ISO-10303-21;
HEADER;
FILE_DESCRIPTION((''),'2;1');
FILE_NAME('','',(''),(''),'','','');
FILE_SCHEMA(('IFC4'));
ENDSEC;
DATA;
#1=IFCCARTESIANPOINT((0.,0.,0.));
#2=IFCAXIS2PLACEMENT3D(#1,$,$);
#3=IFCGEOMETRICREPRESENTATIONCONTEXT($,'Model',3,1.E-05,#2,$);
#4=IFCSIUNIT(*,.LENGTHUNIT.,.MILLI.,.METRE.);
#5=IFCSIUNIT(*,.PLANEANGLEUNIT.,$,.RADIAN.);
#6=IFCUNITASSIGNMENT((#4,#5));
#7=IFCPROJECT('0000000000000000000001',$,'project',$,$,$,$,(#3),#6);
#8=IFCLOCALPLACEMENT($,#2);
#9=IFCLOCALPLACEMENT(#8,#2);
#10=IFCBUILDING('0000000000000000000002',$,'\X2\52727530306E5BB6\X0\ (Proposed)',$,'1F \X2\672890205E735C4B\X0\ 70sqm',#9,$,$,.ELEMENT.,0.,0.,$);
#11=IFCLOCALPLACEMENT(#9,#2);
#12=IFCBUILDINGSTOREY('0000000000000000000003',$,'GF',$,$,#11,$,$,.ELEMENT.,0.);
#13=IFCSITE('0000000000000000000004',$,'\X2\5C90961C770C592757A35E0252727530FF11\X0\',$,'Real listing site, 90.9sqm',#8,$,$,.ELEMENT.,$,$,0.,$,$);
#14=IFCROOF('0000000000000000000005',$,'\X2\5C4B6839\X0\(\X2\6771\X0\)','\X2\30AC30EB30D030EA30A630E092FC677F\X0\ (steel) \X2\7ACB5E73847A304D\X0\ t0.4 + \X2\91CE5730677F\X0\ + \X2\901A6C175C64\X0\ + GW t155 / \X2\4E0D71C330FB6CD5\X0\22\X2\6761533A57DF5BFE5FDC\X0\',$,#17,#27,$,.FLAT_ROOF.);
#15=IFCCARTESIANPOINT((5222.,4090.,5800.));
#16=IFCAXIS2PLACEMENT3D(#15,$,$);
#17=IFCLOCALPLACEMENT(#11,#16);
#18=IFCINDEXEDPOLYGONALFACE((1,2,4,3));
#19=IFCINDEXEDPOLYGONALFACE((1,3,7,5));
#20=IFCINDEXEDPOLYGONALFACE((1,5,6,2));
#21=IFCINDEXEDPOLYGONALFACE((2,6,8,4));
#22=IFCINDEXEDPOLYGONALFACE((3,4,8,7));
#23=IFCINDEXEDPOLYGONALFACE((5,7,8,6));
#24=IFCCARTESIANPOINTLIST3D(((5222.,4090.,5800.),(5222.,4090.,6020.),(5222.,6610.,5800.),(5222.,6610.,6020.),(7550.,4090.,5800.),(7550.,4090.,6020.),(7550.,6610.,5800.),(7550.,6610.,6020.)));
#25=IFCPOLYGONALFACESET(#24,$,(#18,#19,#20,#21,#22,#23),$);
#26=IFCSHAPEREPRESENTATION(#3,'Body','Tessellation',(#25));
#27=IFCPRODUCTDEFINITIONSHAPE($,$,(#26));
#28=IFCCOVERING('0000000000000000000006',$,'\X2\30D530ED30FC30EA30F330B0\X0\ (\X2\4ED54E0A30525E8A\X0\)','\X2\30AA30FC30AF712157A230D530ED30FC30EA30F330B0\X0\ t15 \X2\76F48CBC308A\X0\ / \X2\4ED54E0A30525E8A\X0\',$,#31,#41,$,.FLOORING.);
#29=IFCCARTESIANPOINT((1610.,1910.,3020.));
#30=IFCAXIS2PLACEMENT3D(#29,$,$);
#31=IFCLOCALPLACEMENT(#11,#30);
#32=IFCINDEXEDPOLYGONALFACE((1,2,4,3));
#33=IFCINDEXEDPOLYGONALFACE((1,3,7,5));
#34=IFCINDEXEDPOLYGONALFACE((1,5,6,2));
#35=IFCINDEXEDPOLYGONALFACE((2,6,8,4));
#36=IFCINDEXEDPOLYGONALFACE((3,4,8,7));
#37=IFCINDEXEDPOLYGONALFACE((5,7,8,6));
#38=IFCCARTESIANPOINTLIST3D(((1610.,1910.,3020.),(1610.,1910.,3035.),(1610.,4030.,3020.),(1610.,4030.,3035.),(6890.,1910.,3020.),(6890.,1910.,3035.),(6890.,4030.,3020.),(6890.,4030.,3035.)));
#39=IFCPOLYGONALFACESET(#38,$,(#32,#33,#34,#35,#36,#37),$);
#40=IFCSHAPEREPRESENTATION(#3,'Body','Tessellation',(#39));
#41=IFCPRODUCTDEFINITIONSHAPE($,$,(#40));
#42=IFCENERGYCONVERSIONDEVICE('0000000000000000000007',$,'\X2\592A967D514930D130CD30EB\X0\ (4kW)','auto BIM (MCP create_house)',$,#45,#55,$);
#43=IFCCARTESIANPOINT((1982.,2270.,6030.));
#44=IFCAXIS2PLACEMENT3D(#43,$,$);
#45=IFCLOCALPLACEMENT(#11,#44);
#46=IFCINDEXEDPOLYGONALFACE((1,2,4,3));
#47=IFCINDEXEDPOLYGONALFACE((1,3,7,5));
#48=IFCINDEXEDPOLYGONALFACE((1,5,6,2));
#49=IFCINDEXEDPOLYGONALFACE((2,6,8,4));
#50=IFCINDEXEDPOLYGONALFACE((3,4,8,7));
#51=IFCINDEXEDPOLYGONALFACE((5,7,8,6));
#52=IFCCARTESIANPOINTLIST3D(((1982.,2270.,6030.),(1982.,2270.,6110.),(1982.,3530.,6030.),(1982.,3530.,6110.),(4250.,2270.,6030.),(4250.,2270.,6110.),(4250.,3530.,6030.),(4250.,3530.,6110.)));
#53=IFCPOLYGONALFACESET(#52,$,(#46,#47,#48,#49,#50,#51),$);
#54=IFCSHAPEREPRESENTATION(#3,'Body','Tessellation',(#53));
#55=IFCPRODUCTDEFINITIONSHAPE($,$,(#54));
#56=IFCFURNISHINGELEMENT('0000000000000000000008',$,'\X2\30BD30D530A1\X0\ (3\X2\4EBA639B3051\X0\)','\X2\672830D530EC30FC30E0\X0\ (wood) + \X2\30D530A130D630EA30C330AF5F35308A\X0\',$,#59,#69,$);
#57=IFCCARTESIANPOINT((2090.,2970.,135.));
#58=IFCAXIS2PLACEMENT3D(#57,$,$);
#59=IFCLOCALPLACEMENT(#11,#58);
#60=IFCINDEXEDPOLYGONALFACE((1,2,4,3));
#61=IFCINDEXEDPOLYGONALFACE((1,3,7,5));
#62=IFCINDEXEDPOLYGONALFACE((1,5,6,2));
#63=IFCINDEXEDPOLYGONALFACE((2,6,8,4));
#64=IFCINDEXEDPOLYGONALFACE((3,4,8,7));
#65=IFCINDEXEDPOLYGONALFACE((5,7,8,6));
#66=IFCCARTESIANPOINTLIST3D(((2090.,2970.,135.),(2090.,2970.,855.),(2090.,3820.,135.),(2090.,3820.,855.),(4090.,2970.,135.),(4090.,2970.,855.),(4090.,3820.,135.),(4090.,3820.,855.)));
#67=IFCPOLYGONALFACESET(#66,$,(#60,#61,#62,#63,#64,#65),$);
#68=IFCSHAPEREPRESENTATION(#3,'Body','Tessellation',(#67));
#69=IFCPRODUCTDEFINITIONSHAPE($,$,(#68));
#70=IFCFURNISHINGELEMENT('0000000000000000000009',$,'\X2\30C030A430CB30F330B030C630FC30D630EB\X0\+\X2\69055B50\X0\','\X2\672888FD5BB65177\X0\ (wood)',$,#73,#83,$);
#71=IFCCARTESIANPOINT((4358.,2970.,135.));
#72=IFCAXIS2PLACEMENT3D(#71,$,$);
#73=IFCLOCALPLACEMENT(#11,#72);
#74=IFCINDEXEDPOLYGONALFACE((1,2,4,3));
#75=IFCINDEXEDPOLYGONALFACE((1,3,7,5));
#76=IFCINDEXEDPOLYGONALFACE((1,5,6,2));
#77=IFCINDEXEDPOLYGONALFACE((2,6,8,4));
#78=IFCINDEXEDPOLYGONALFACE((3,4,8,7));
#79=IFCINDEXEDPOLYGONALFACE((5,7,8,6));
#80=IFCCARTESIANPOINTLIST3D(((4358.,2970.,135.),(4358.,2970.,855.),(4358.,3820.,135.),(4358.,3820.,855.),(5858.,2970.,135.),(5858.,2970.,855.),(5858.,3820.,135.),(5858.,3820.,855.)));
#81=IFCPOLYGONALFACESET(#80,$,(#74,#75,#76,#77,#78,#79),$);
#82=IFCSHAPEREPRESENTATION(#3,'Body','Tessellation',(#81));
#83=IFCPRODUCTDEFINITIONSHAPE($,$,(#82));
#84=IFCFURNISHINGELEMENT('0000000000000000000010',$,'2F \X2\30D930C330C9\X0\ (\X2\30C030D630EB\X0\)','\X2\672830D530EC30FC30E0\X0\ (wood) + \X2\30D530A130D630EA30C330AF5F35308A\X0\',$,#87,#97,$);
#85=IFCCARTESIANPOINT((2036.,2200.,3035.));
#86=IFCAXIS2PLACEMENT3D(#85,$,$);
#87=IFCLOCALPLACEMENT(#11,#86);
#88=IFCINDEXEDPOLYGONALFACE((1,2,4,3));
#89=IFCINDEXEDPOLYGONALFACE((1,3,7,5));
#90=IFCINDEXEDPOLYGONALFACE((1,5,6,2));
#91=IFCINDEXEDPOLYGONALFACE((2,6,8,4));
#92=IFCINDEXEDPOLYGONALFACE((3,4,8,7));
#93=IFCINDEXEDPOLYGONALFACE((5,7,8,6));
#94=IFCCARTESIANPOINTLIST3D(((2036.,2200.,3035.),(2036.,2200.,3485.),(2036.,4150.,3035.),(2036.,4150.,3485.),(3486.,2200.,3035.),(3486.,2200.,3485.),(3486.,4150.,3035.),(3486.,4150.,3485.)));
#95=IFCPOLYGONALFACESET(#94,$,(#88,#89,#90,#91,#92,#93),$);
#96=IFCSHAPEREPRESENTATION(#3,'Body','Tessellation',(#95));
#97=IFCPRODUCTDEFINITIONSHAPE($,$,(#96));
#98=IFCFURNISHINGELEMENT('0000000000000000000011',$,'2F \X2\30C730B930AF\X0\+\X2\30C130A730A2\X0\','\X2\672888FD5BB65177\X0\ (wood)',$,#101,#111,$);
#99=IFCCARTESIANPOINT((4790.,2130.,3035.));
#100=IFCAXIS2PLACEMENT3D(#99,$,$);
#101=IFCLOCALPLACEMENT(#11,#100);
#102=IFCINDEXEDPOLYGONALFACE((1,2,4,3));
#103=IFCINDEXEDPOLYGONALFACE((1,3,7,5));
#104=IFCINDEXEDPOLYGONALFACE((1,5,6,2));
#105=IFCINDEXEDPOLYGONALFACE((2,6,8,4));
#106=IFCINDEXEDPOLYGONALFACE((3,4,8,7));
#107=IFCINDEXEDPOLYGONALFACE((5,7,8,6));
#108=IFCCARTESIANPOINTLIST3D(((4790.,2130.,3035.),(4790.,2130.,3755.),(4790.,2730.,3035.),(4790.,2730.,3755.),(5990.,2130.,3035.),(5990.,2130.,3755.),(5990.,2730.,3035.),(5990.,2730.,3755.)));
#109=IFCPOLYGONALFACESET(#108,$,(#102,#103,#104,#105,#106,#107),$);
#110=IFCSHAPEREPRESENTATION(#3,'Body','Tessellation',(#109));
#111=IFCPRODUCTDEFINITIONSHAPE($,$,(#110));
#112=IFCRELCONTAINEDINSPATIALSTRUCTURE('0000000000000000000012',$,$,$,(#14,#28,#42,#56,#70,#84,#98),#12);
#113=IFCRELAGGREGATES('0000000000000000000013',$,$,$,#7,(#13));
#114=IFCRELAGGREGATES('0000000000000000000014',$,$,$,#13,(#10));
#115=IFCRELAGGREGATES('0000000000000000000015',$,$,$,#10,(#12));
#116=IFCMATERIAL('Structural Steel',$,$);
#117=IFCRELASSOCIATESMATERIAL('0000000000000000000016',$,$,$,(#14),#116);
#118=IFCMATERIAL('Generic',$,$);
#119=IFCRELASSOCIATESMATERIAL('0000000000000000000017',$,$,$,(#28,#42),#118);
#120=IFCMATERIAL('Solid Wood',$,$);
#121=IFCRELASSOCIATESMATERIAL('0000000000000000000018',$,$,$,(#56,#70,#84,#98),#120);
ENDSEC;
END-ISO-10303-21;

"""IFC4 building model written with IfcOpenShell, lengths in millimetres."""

from ifc_helpers import new_model, si_unit, frame, frame_2d, origin, place, context, project, spatial, rectangle, extrude, material, element, save


model = new_model("IFC4")

# Units and contexts
model_context = context("Model", 3, precision=1e-05, world=origin())
ifc_project = project(units=[si_unit("LENGTHUNIT", "METRE", prefix="MILLI"), si_unit("PLANEANGLEUNIT", "RADIAN")], contexts=[model_context])

# Site, building, storey
site_placement = place(None, origin())
site = spatial("IfcSite", under=ifc_project, at=site_placement, Name="岐阜県大垣市割田１", ObjectType="Real listing site, 90.9sqm", CompositionType="ELEMENT", RefElevation=0.0)
building_placement = place(site_placement, origin())
building = spatial("IfcBuilding", under=site, at=building_placement, Name="割田の家 (Proposed)", ObjectType="1F 木造平屋 70sqm", CompositionType="ELEMENT", ElevationOfRefHeight=0.0, ElevationOfTerrain=0.0)
storey_placement = place(building_placement, origin())
storey = spatial("IfcBuildingStorey", under=building, at=storey_placement, Name="GF", CompositionType="ELEMENT", Elevation=0.0)

# Shared definitions
ifc_material_1 = material(Name="Solid Wood")

# Roof
ifc_material_2 = material(Name="Structural Steel")
roof_1_placement = place(storey_placement, frame((5222.0, 4090.0, 5800.0)))
element("IfcRoof", 1, at=roof_1_placement, inside=storey, material=ifc_material_2, Name="屋根(東)", Description="ガルバリウム鋼板 (steel) 立平葺き t0.4 + 野地板 + 通気層 + GW t155 / 不燃・法22条区域対応", PredefinedType="FLAT_ROOF", context=model_context, shape_type="SweptSolid", body=[
    extrude(rectangle(XDim=2328.0, YDim=2520.0, at=frame_2d((1164.0, 1260.0))), frame((5222.0, 4090.0, 5800.0)), (0.0, 0.0, 1.0), 220.0),
])

# Covering
ifc_material_3 = material(Name="Generic")
covering_placement = place(storey_placement, frame((1610.0, 1910.0, 3020.0)))
element("IfcCovering", 2, at=covering_placement, inside=storey, material=ifc_material_3, Name="フローリング (仕上げ床)", Description="オーク無垢フローリング t15 直貼り / 仕上げ床", PredefinedType="FLOORING", context=model_context, shape_type="SweptSolid", body=[
    extrude(rectangle(XDim=5280.0, YDim=2120.0, at=frame_2d((2640.0, 1060.0))), frame((1610.0, 1910.0, 3020.0)), (0.0, 0.0, 1.0), 15.0),
])

# Energy conversion device
energy_conversion_device_placement = place(storey_placement, frame((1982.0, 2270.0, 6030.0)))
element("IfcEnergyConversionDevice", 3, at=energy_conversion_device_placement, inside=storey, material=ifc_material_3, Name="太陽光パネル (4kW)", Description="auto BIM (MCP create_house)", context=model_context, shape_type="SweptSolid", body=[
    extrude(rectangle(XDim=2268.0, YDim=1260.0, at=frame_2d((1134.0, 630.0))), frame((1982.0, 2270.0, 6030.0)), (0.0, 0.0, 1.0), 80.0),
])

# Furnishing elements
furnishing_1_placement = place(storey_placement, frame((2090.0, 2970.0, 135.0)))
element("IfcFurnishingElement", 4, at=furnishing_1_placement, inside=storey, material=ifc_material_1, Name="ソファ (3人掛け)", Description="木フレーム (wood) + ファブリック張り", context=model_context, shape_type="SweptSolid", body=[
    extrude(rectangle(XDim=2000.0, YDim=850.0, at=frame_2d((1000.0, 425.0))), frame((2090.0, 2970.0, 135.0)), (0.0, 0.0, 1.0), 720.0),
])
furnishing_2_placement = place(storey_placement, frame((4358.0, 2970.0, 135.0)))
element("IfcFurnishingElement", 5, at=furnishing_2_placement, inside=storey, material=ifc_material_1, Name="ダイニングテーブル+椅子", Description="木製家具 (wood)", context=model_context, shape_type="SweptSolid", body=[
    extrude(rectangle(XDim=1500.0, YDim=850.0, at=frame_2d((750.0, 425.0))), frame((4358.0, 2970.0, 135.0)), (0.0, 0.0, 1.0), 720.0),
])
furnishing_3_placement = place(storey_placement, frame((2036.0, 2200.0, 3035.0)))
element("IfcFurnishingElement", 6, at=furnishing_3_placement, inside=storey, material=ifc_material_1, Name="2F ベッド (ダブル)", Description="木フレーム (wood) + ファブリック張り", context=model_context, shape_type="SweptSolid", body=[
    extrude(rectangle(XDim=1450.0, YDim=1950.0, at=frame_2d((725.0, 975.0))), frame((2036.0, 2200.0, 3035.0)), (0.0, 0.0, 1.0), 450.0),
])
furnishing_4_placement = place(storey_placement, frame((4790.0, 2130.0, 3035.0)))
element("IfcFurnishingElement", 7, at=furnishing_4_placement, inside=storey, material=ifc_material_1, Name="2F デスク+チェア", Description="木製家具 (wood)", context=model_context, shape_type="SweptSolid", body=[
    extrude(rectangle(XDim=1200.0, YDim=600.0, at=frame_2d((600.0, 300.0))), frame((4790.0, 2130.0, 3035.0)), (0.0, 0.0, 1.0), 720.0),
])

save(model, "model.ifc")
